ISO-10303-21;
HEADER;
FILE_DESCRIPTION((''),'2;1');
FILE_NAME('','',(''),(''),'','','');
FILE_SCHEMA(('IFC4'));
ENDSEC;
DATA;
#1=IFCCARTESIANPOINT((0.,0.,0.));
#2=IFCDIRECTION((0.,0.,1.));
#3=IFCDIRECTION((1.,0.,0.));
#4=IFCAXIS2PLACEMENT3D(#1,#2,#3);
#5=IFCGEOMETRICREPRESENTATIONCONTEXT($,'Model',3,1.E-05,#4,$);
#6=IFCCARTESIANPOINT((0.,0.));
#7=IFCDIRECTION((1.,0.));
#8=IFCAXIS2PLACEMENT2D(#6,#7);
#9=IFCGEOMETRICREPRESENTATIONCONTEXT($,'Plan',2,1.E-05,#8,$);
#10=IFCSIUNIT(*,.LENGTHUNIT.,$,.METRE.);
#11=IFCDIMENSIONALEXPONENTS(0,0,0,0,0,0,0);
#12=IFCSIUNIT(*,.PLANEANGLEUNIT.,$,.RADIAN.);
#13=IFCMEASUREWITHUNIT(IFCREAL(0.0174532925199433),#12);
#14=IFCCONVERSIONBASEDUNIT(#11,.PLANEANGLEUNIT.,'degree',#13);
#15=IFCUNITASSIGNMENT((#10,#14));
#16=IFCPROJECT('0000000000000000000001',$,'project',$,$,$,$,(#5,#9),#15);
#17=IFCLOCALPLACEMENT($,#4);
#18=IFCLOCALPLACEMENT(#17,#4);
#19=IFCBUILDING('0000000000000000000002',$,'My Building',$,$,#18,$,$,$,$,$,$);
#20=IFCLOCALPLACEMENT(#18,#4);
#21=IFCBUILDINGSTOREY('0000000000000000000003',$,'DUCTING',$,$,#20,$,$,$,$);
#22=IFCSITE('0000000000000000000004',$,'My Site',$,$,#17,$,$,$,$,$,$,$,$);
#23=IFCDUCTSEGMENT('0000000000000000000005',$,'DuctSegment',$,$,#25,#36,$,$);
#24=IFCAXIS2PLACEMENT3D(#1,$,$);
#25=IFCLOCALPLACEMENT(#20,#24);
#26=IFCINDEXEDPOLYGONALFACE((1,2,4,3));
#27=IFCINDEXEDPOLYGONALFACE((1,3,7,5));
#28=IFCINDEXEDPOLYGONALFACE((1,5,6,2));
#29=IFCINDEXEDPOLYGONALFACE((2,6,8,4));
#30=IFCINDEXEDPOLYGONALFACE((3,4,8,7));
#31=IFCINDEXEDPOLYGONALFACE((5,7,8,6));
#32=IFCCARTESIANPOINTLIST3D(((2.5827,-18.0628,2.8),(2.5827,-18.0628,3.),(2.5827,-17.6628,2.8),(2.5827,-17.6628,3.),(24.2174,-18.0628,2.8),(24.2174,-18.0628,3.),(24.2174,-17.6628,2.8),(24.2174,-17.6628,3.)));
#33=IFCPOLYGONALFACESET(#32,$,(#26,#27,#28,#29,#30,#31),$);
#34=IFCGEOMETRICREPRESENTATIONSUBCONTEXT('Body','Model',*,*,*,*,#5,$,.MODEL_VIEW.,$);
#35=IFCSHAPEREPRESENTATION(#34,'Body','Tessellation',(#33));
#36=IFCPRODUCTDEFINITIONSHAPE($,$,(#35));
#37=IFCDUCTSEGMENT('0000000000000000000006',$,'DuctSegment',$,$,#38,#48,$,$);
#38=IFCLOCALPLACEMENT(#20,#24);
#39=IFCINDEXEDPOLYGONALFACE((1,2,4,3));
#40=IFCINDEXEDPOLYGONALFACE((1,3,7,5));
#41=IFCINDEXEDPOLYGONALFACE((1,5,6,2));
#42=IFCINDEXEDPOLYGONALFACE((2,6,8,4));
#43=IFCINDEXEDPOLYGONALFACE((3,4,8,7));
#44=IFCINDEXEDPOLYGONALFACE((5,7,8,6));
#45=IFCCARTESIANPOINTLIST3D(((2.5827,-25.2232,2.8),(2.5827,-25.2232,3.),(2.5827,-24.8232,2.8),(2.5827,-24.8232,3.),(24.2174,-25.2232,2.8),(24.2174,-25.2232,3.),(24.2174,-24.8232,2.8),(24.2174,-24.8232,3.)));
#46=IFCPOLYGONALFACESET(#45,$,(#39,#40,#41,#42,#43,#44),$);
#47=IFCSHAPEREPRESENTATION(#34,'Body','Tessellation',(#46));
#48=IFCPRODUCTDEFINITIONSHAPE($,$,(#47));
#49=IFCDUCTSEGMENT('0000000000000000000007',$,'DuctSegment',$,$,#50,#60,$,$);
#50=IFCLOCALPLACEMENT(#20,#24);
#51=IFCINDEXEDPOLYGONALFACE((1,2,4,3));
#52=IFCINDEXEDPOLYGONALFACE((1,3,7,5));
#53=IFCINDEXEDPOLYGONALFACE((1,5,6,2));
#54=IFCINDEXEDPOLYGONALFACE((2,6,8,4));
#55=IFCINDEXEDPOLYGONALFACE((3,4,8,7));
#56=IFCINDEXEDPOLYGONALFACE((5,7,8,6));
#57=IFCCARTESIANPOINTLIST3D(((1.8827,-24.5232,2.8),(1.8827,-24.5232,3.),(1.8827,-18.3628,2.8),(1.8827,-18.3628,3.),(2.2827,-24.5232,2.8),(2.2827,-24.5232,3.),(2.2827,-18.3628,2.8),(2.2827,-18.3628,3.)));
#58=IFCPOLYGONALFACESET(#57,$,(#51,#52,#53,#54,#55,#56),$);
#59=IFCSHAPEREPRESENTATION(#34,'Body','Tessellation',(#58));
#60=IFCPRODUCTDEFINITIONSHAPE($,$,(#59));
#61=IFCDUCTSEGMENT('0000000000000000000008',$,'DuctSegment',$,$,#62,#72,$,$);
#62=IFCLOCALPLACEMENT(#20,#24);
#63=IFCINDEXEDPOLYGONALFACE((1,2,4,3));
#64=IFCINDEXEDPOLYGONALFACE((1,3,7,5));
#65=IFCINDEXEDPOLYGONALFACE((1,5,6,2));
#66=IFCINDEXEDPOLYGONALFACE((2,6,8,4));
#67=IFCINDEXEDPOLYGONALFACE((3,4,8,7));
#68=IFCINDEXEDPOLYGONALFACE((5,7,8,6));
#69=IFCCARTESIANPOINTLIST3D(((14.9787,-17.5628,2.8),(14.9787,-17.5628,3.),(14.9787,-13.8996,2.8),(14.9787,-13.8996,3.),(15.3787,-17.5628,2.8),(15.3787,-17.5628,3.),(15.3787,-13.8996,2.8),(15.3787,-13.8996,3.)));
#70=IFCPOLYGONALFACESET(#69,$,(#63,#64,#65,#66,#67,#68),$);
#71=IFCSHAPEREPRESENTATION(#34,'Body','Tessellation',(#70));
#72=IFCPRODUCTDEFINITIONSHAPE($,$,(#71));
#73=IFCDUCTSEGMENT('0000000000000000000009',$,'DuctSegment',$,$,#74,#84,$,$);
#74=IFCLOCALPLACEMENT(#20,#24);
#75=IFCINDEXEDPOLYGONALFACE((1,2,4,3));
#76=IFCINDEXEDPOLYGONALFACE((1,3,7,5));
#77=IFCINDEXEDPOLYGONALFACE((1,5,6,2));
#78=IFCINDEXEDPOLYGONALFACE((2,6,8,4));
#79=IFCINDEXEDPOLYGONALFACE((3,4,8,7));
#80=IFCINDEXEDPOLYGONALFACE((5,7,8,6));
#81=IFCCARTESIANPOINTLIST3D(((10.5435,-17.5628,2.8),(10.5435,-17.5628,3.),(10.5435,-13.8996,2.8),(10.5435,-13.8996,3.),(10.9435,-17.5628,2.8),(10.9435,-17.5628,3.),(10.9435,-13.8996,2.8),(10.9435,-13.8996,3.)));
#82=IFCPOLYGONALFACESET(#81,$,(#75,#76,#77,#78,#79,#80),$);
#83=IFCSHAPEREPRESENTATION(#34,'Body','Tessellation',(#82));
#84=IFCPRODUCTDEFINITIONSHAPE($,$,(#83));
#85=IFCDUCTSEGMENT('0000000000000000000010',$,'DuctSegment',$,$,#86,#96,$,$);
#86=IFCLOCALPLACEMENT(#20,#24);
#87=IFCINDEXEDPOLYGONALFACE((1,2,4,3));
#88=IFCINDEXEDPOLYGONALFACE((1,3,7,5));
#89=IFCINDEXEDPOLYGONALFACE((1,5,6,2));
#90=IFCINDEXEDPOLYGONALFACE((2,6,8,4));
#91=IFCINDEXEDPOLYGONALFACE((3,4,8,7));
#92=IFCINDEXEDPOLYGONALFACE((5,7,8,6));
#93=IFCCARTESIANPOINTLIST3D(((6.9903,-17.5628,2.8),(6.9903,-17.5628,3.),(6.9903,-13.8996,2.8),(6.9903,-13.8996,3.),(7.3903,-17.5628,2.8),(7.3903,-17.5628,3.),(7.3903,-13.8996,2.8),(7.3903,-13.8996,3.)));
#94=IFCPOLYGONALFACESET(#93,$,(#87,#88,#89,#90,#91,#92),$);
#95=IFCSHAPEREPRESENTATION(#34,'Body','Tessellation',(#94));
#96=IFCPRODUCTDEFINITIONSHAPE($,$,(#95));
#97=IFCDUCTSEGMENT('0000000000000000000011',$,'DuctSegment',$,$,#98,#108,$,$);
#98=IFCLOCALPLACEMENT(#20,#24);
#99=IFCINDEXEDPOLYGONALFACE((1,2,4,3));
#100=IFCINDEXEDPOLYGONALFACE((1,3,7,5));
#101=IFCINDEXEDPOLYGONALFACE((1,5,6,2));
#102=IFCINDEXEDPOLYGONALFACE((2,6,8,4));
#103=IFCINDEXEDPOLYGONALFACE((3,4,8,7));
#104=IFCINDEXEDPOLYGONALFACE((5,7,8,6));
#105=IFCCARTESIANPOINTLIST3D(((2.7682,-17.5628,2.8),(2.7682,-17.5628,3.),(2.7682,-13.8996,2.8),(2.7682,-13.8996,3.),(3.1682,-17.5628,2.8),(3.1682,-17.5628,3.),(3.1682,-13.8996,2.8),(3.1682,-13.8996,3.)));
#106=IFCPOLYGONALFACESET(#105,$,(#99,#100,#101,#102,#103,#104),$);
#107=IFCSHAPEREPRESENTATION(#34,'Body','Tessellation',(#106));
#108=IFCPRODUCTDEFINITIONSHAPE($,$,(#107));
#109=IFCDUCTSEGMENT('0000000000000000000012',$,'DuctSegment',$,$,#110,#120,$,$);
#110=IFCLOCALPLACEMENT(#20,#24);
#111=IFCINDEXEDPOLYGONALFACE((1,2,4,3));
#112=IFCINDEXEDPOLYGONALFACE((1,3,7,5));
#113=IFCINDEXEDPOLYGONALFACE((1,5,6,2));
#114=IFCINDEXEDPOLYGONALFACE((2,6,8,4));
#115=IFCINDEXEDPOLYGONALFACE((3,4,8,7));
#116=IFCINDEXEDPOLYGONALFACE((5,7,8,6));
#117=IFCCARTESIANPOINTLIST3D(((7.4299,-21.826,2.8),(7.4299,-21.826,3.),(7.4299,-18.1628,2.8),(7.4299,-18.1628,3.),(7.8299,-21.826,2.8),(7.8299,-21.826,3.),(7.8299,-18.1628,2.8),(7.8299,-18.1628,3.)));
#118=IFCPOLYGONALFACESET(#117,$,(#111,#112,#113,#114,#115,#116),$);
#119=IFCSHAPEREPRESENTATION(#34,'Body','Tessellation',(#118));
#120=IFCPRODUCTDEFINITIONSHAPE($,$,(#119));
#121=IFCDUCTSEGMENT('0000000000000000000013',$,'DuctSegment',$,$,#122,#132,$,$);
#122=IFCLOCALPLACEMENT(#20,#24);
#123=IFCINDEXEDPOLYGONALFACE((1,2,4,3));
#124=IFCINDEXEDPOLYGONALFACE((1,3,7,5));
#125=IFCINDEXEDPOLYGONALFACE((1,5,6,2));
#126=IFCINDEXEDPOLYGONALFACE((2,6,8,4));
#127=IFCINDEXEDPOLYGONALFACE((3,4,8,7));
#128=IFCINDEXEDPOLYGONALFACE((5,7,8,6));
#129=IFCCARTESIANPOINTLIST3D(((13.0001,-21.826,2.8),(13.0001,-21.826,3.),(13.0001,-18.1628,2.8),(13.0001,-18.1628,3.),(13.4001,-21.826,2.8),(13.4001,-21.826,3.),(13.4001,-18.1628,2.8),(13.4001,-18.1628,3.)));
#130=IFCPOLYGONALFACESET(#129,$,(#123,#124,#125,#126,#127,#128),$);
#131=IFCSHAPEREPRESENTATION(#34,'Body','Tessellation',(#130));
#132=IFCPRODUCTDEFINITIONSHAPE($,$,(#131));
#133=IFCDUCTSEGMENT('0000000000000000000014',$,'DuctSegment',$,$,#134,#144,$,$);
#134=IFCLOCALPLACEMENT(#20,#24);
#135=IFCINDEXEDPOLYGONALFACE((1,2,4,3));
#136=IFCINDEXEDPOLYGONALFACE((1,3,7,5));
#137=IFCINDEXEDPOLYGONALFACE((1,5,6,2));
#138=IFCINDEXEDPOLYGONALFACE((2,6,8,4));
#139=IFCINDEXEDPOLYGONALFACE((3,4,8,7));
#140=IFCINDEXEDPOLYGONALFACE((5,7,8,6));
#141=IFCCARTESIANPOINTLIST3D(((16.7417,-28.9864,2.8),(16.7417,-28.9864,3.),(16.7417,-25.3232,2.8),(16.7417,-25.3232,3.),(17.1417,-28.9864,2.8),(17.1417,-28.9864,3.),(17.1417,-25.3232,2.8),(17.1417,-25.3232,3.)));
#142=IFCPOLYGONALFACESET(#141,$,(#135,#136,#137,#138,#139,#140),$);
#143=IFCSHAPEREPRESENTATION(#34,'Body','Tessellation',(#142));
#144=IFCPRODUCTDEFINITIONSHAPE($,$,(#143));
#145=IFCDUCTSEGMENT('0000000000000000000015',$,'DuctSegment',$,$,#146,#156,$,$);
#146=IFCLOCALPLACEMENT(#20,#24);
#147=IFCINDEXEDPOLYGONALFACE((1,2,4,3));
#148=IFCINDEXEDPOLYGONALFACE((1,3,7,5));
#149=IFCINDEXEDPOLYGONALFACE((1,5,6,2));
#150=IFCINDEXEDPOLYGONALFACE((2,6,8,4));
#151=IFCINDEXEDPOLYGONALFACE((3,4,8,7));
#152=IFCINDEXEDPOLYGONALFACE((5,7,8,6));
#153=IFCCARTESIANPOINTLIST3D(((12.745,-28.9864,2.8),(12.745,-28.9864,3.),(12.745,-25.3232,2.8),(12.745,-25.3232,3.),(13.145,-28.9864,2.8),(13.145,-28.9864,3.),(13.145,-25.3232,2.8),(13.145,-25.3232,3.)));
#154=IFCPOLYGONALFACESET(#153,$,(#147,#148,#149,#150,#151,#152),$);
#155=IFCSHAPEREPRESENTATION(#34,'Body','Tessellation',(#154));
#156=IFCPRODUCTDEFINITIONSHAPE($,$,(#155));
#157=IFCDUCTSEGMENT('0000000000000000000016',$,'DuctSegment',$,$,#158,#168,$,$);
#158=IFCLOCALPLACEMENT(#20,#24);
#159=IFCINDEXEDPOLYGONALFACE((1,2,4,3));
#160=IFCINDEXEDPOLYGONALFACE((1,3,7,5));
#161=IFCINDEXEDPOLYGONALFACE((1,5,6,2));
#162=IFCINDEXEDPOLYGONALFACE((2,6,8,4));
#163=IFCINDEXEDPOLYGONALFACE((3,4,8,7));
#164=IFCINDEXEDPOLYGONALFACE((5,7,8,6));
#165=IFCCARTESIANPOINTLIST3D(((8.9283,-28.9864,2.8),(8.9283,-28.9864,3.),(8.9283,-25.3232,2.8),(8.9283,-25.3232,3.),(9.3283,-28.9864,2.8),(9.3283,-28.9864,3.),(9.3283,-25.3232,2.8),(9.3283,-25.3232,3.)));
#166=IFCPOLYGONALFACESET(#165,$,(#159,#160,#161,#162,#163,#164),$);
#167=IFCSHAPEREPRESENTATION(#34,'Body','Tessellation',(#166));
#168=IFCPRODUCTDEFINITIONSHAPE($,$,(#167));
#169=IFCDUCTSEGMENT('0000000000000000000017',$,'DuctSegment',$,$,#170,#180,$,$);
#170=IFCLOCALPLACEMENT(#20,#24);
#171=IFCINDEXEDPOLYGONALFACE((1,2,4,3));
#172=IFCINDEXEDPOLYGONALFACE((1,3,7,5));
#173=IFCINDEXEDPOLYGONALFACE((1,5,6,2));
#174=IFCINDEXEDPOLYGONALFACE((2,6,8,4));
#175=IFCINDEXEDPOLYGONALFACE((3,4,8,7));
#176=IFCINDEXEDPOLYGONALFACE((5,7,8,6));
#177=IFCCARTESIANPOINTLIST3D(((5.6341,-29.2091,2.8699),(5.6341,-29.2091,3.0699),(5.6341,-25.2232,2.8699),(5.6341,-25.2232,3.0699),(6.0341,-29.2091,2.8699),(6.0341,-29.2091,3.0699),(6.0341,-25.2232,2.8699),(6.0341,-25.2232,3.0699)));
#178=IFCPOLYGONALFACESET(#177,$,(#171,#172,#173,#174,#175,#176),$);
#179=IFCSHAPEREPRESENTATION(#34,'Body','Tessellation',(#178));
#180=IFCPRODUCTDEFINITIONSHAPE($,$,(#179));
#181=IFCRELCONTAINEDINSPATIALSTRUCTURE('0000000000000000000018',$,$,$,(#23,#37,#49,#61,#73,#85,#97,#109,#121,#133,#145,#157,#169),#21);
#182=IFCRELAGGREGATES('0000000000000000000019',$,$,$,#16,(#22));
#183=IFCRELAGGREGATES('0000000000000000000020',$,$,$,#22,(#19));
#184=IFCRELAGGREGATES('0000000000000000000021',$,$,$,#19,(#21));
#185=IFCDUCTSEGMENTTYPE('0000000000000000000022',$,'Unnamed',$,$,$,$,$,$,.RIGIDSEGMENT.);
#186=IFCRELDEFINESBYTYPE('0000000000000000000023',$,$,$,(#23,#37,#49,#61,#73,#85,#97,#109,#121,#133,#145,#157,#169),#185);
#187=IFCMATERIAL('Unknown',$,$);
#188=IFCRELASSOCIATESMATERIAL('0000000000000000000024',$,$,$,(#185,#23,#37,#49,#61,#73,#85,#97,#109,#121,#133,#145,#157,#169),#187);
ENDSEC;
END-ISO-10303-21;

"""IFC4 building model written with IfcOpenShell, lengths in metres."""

from ifc_helpers import new_model, entity, si_unit, converted_unit, frame, origin_with_axes, origin_2d_with_axis, place, context, subcontext, project, spatial, rectangle, extrude, material, material_profile, profile_set, profile_usage, type_object, element, save


model = new_model("IFC4")

# Units and contexts
model_context = context("Model", 3, precision=1e-05, world=origin_with_axes())
plan_context = context("Plan", 2, precision=1e-05, world=origin_2d_with_axis())
body_context = subcontext(model_context, "Body", "Model", "MODEL_VIEW")
ifc_project = project(units=[si_unit("LENGTHUNIT", "METRE"), converted_unit("PLANEANGLEUNIT", "degree", entity("IfcReal", 0.0174532925199433), si_unit("PLANEANGLEUNIT", "RADIAN"), dimensions=[0, 0, 0, 0, 0, 0, 0])], contexts=[model_context, plan_context])

# Site, building, storey
site_placement = place(None, origin_with_axes())
site = spatial("IfcSite", under=ifc_project, at=site_placement, Name="My Site")
building_placement = place(site_placement, origin_with_axes())
building = spatial("IfcBuilding", under=site, at=building_placement, Name="My Building")
storey_placement = place(building_placement, origin_with_axes())
storey = spatial("IfcBuildingStorey", under=building, at=storey_placement, Name="DUCTING")

# Duct segments
ifc_material = material(Name="Unknown")
ifc_material_profile_1 = material_profile(ifc_material, rectangle(XDim=0.4, YDim=0.2))
ifc_profile_set_1 = profile_set([ifc_material_profile_1])
ifc_profile_usage_1 = profile_usage(ifc_profile_set_1, cardinal=5)
duct_segment_type = type_object("IfcDuctSegmentType", Name="Unnamed", PredefinedType="RIGIDSEGMENT", material=ifc_profile_set_1)
duct_segment_1_placement = place(storey_placement, frame((2.5827, -17.8628, 2.9), z_axis=(1.0, 0.0, 0.0), x_axis=(0.0, 1.0, 0.0)))
element("IfcDuctSegment", 1, at=duct_segment_1_placement, inside=storey, type_object=duct_segment_type, material=ifc_profile_usage_1, Name="DuctSegment", context=body_context, shape_type="SweptSolid", body=[
    extrude(rectangle(XDim=0.4, YDim=0.2), origin_with_axes(), (0.0, 0.0, 1.0), 21.6346),
])
ifc_profile_usage_2 = profile_usage(ifc_profile_set_1, cardinal=5)
duct_segment_2_placement = place(storey_placement, frame((2.5827, -25.0232, 2.9), z_axis=(1.0, 0.0, 0.0), x_axis=(0.0, 1.0, 0.0)))
element("IfcDuctSegment", 2, at=duct_segment_2_placement, inside=storey, type_object=duct_segment_type, material=ifc_profile_usage_2, Name="DuctSegment", context=body_context, shape_type="SweptSolid", body=[
    extrude(rectangle(XDim=0.4, YDim=0.2), origin_with_axes(), (0.0, 0.0, 1.0), 21.6346),
])
ifc_profile_usage_3 = profile_usage(ifc_profile_set_1, cardinal=5)
duct_segment_3_placement = place(storey_placement, frame((2.0827, -18.3628, 2.9), z_axis=(0.0, -1.0, 0.0), x_axis=(1.0, 0.0, 0.0)))
element("IfcDuctSegment", 3, at=duct_segment_3_placement, inside=storey, type_object=duct_segment_type, material=ifc_profile_usage_3, Name="DuctSegment", context=body_context, shape_type="SweptSolid", body=[
    extrude(rectangle(XDim=0.4, YDim=0.2), origin_with_axes(), (0.0, 0.0, 1.0), 6.1604),
])
ifc_profile_usage_4 = profile_usage(ifc_profile_set_1, cardinal=5)
duct_segment_4_placement = place(storey_placement, frame((15.1787, -17.5628, 2.9), z_axis=(0.0, 1.0, 0.0), x_axis=(-1.0, 0.0, 0.0)))
element("IfcDuctSegment", 4, at=duct_segment_4_placement, inside=storey, type_object=duct_segment_type, material=ifc_profile_usage_4, Name="DuctSegment", context=body_context, shape_type="SweptSolid", body=[
    extrude(rectangle(XDim=0.4, YDim=0.2), origin_with_axes(), (0.0, 0.0, 1.0), 3.6632),
])
ifc_profile_usage_5 = profile_usage(ifc_profile_set_1, cardinal=5)
duct_segment_5_placement = place(storey_placement, frame((10.7435, -17.5628, 2.9), z_axis=(0.0, 1.0, 0.0), x_axis=(-1.0, 0.0, 0.0)))
element("IfcDuctSegment", 5, at=duct_segment_5_placement, inside=storey, type_object=duct_segment_type, material=ifc_profile_usage_5, Name="DuctSegment", context=body_context, shape_type="SweptSolid", body=[
    extrude(rectangle(XDim=0.4, YDim=0.2), origin_with_axes(), (0.0, 0.0, 1.0), 3.6632),
])
ifc_profile_usage_6 = profile_usage(ifc_profile_set_1, cardinal=5)
duct_segment_6_placement = place(storey_placement, frame((7.1903, -17.5628, 2.9), z_axis=(0.0, 1.0, 0.0), x_axis=(-1.0, 0.0, 0.0)))
element("IfcDuctSegment", 6, at=duct_segment_6_placement, inside=storey, type_object=duct_segment_type, material=ifc_profile_usage_6, Name="DuctSegment", context=body_context, shape_type="SweptSolid", body=[
    extrude(rectangle(XDim=0.4, YDim=0.2), origin_with_axes(), (0.0, 0.0, 1.0), 3.6632),
])
ifc_profile_usage_7 = profile_usage(ifc_profile_set_1, cardinal=5)
duct_segment_7_placement = place(storey_placement, frame((2.9682, -17.5628, 2.9), z_axis=(0.0, 1.0, 0.0), x_axis=(-1.0, 0.0, 0.0)))
element("IfcDuctSegment", 7, at=duct_segment_7_placement, inside=storey, type_object=duct_segment_type, material=ifc_profile_usage_7, Name="DuctSegment", context=body_context, shape_type="SweptSolid", body=[
    extrude(rectangle(XDim=0.4, YDim=0.2), origin_with_axes(), (0.0, 0.0, 1.0), 3.6632),
])
ifc_profile_usage_8 = profile_usage(ifc_profile_set_1, cardinal=5)
duct_segment_8_placement = place(storey_placement, frame((7.6299, -18.1628, 2.9), z_axis=(0.0, -1.0, 0.0), x_axis=(1.0, 0.0, 0.0)))
element("IfcDuctSegment", 8, at=duct_segment_8_placement, inside=storey, type_object=duct_segment_type, material=ifc_profile_usage_8, Name="DuctSegment", context=body_context, shape_type="SweptSolid", body=[
    extrude(rectangle(XDim=0.4, YDim=0.2), origin_with_axes(), (0.0, 0.0, 1.0), 3.6632),
])
ifc_profile_usage_9 = profile_usage(ifc_profile_set_1, cardinal=5)
duct_segment_9_placement = place(storey_placement, frame((13.2001, -18.1628, 2.9), z_axis=(0.0, -1.0, 0.0), x_axis=(1.0, 0.0, 0.0)))
element("IfcDuctSegment", 9, at=duct_segment_9_placement, inside=storey, type_object=duct_segment_type, material=ifc_profile_usage_9, Name="DuctSegment", context=body_context, shape_type="SweptSolid", body=[
    extrude(rectangle(XDim=0.4, YDim=0.2), origin_with_axes(), (0.0, 0.0, 1.0), 3.6632),
])
ifc_profile_usage_10 = profile_usage(ifc_profile_set_1, cardinal=5)
duct_segment_10_placement = place(storey_placement, frame((16.9417, -25.3232, 2.9), z_axis=(0.0, -1.0, 0.0), x_axis=(1.0, 0.0, 0.0)))
element("IfcDuctSegment", 10, at=duct_segment_10_placement, inside=storey, type_object=duct_segment_type, material=ifc_profile_usage_10, Name="DuctSegment", context=body_context, shape_type="SweptSolid", body=[
    extrude(rectangle(XDim=0.4, YDim=0.2), origin_with_axes(), (0.0, 0.0, 1.0), 3.6632),
])
ifc_profile_usage_11 = profile_usage(ifc_profile_set_1, cardinal=5)
duct_segment_11_placement = place(storey_placement, frame((12.945, -25.3232, 2.9), z_axis=(0.0, -1.0, 0.0), x_axis=(1.0, 0.0, 0.0)))
element("IfcDuctSegment", 11, at=duct_segment_11_placement, inside=storey, type_object=duct_segment_type, material=ifc_profile_usage_11, Name="DuctSegment", context=body_context, shape_type="SweptSolid", body=[
    extrude(rectangle(XDim=0.4, YDim=0.2), origin_with_axes(), (0.0, 0.0, 1.0), 3.6632),
])
ifc_profile_usage_12 = profile_usage(ifc_profile_set_1, cardinal=5)
duct_segment_12_placement = place(storey_placement, frame((9.1283, -25.3232, 2.9), z_axis=(0.0, -1.0, 0.0), x_axis=(1.0, 0.0, 0.0)))
element("IfcDuctSegment", 12, at=duct_segment_12_placement, inside=storey, type_object=duct_segment_type, material=ifc_profile_usage_12, Name="DuctSegment", context=body_context, shape_type="SweptSolid", body=[
    extrude(rectangle(XDim=0.4, YDim=0.2), origin_with_axes(), (0.0, 0.0, 1.0), 3.6632),
])
ifc_profile_usage_13 = profile_usage(ifc_profile_set_1, cardinal=5)
duct_segment_13_placement = place(storey_placement, frame((5.8341, -25.2232, 2.9699), z_axis=(0.0, -1.0, 0.0), x_axis=(1.0, 0.0, 0.0)))
element("IfcDuctSegment", 13, at=duct_segment_13_placement, inside=storey, type_object=duct_segment_type, material=ifc_profile_usage_13, Name="DuctSegment", context=body_context, shape_type="SweptSolid", body=[
    extrude(rectangle(XDim=0.4, YDim=0.2), origin_with_axes(), (0.0, 0.0, 1.0), 3.9859),
])

save(model, "model.ifc")
